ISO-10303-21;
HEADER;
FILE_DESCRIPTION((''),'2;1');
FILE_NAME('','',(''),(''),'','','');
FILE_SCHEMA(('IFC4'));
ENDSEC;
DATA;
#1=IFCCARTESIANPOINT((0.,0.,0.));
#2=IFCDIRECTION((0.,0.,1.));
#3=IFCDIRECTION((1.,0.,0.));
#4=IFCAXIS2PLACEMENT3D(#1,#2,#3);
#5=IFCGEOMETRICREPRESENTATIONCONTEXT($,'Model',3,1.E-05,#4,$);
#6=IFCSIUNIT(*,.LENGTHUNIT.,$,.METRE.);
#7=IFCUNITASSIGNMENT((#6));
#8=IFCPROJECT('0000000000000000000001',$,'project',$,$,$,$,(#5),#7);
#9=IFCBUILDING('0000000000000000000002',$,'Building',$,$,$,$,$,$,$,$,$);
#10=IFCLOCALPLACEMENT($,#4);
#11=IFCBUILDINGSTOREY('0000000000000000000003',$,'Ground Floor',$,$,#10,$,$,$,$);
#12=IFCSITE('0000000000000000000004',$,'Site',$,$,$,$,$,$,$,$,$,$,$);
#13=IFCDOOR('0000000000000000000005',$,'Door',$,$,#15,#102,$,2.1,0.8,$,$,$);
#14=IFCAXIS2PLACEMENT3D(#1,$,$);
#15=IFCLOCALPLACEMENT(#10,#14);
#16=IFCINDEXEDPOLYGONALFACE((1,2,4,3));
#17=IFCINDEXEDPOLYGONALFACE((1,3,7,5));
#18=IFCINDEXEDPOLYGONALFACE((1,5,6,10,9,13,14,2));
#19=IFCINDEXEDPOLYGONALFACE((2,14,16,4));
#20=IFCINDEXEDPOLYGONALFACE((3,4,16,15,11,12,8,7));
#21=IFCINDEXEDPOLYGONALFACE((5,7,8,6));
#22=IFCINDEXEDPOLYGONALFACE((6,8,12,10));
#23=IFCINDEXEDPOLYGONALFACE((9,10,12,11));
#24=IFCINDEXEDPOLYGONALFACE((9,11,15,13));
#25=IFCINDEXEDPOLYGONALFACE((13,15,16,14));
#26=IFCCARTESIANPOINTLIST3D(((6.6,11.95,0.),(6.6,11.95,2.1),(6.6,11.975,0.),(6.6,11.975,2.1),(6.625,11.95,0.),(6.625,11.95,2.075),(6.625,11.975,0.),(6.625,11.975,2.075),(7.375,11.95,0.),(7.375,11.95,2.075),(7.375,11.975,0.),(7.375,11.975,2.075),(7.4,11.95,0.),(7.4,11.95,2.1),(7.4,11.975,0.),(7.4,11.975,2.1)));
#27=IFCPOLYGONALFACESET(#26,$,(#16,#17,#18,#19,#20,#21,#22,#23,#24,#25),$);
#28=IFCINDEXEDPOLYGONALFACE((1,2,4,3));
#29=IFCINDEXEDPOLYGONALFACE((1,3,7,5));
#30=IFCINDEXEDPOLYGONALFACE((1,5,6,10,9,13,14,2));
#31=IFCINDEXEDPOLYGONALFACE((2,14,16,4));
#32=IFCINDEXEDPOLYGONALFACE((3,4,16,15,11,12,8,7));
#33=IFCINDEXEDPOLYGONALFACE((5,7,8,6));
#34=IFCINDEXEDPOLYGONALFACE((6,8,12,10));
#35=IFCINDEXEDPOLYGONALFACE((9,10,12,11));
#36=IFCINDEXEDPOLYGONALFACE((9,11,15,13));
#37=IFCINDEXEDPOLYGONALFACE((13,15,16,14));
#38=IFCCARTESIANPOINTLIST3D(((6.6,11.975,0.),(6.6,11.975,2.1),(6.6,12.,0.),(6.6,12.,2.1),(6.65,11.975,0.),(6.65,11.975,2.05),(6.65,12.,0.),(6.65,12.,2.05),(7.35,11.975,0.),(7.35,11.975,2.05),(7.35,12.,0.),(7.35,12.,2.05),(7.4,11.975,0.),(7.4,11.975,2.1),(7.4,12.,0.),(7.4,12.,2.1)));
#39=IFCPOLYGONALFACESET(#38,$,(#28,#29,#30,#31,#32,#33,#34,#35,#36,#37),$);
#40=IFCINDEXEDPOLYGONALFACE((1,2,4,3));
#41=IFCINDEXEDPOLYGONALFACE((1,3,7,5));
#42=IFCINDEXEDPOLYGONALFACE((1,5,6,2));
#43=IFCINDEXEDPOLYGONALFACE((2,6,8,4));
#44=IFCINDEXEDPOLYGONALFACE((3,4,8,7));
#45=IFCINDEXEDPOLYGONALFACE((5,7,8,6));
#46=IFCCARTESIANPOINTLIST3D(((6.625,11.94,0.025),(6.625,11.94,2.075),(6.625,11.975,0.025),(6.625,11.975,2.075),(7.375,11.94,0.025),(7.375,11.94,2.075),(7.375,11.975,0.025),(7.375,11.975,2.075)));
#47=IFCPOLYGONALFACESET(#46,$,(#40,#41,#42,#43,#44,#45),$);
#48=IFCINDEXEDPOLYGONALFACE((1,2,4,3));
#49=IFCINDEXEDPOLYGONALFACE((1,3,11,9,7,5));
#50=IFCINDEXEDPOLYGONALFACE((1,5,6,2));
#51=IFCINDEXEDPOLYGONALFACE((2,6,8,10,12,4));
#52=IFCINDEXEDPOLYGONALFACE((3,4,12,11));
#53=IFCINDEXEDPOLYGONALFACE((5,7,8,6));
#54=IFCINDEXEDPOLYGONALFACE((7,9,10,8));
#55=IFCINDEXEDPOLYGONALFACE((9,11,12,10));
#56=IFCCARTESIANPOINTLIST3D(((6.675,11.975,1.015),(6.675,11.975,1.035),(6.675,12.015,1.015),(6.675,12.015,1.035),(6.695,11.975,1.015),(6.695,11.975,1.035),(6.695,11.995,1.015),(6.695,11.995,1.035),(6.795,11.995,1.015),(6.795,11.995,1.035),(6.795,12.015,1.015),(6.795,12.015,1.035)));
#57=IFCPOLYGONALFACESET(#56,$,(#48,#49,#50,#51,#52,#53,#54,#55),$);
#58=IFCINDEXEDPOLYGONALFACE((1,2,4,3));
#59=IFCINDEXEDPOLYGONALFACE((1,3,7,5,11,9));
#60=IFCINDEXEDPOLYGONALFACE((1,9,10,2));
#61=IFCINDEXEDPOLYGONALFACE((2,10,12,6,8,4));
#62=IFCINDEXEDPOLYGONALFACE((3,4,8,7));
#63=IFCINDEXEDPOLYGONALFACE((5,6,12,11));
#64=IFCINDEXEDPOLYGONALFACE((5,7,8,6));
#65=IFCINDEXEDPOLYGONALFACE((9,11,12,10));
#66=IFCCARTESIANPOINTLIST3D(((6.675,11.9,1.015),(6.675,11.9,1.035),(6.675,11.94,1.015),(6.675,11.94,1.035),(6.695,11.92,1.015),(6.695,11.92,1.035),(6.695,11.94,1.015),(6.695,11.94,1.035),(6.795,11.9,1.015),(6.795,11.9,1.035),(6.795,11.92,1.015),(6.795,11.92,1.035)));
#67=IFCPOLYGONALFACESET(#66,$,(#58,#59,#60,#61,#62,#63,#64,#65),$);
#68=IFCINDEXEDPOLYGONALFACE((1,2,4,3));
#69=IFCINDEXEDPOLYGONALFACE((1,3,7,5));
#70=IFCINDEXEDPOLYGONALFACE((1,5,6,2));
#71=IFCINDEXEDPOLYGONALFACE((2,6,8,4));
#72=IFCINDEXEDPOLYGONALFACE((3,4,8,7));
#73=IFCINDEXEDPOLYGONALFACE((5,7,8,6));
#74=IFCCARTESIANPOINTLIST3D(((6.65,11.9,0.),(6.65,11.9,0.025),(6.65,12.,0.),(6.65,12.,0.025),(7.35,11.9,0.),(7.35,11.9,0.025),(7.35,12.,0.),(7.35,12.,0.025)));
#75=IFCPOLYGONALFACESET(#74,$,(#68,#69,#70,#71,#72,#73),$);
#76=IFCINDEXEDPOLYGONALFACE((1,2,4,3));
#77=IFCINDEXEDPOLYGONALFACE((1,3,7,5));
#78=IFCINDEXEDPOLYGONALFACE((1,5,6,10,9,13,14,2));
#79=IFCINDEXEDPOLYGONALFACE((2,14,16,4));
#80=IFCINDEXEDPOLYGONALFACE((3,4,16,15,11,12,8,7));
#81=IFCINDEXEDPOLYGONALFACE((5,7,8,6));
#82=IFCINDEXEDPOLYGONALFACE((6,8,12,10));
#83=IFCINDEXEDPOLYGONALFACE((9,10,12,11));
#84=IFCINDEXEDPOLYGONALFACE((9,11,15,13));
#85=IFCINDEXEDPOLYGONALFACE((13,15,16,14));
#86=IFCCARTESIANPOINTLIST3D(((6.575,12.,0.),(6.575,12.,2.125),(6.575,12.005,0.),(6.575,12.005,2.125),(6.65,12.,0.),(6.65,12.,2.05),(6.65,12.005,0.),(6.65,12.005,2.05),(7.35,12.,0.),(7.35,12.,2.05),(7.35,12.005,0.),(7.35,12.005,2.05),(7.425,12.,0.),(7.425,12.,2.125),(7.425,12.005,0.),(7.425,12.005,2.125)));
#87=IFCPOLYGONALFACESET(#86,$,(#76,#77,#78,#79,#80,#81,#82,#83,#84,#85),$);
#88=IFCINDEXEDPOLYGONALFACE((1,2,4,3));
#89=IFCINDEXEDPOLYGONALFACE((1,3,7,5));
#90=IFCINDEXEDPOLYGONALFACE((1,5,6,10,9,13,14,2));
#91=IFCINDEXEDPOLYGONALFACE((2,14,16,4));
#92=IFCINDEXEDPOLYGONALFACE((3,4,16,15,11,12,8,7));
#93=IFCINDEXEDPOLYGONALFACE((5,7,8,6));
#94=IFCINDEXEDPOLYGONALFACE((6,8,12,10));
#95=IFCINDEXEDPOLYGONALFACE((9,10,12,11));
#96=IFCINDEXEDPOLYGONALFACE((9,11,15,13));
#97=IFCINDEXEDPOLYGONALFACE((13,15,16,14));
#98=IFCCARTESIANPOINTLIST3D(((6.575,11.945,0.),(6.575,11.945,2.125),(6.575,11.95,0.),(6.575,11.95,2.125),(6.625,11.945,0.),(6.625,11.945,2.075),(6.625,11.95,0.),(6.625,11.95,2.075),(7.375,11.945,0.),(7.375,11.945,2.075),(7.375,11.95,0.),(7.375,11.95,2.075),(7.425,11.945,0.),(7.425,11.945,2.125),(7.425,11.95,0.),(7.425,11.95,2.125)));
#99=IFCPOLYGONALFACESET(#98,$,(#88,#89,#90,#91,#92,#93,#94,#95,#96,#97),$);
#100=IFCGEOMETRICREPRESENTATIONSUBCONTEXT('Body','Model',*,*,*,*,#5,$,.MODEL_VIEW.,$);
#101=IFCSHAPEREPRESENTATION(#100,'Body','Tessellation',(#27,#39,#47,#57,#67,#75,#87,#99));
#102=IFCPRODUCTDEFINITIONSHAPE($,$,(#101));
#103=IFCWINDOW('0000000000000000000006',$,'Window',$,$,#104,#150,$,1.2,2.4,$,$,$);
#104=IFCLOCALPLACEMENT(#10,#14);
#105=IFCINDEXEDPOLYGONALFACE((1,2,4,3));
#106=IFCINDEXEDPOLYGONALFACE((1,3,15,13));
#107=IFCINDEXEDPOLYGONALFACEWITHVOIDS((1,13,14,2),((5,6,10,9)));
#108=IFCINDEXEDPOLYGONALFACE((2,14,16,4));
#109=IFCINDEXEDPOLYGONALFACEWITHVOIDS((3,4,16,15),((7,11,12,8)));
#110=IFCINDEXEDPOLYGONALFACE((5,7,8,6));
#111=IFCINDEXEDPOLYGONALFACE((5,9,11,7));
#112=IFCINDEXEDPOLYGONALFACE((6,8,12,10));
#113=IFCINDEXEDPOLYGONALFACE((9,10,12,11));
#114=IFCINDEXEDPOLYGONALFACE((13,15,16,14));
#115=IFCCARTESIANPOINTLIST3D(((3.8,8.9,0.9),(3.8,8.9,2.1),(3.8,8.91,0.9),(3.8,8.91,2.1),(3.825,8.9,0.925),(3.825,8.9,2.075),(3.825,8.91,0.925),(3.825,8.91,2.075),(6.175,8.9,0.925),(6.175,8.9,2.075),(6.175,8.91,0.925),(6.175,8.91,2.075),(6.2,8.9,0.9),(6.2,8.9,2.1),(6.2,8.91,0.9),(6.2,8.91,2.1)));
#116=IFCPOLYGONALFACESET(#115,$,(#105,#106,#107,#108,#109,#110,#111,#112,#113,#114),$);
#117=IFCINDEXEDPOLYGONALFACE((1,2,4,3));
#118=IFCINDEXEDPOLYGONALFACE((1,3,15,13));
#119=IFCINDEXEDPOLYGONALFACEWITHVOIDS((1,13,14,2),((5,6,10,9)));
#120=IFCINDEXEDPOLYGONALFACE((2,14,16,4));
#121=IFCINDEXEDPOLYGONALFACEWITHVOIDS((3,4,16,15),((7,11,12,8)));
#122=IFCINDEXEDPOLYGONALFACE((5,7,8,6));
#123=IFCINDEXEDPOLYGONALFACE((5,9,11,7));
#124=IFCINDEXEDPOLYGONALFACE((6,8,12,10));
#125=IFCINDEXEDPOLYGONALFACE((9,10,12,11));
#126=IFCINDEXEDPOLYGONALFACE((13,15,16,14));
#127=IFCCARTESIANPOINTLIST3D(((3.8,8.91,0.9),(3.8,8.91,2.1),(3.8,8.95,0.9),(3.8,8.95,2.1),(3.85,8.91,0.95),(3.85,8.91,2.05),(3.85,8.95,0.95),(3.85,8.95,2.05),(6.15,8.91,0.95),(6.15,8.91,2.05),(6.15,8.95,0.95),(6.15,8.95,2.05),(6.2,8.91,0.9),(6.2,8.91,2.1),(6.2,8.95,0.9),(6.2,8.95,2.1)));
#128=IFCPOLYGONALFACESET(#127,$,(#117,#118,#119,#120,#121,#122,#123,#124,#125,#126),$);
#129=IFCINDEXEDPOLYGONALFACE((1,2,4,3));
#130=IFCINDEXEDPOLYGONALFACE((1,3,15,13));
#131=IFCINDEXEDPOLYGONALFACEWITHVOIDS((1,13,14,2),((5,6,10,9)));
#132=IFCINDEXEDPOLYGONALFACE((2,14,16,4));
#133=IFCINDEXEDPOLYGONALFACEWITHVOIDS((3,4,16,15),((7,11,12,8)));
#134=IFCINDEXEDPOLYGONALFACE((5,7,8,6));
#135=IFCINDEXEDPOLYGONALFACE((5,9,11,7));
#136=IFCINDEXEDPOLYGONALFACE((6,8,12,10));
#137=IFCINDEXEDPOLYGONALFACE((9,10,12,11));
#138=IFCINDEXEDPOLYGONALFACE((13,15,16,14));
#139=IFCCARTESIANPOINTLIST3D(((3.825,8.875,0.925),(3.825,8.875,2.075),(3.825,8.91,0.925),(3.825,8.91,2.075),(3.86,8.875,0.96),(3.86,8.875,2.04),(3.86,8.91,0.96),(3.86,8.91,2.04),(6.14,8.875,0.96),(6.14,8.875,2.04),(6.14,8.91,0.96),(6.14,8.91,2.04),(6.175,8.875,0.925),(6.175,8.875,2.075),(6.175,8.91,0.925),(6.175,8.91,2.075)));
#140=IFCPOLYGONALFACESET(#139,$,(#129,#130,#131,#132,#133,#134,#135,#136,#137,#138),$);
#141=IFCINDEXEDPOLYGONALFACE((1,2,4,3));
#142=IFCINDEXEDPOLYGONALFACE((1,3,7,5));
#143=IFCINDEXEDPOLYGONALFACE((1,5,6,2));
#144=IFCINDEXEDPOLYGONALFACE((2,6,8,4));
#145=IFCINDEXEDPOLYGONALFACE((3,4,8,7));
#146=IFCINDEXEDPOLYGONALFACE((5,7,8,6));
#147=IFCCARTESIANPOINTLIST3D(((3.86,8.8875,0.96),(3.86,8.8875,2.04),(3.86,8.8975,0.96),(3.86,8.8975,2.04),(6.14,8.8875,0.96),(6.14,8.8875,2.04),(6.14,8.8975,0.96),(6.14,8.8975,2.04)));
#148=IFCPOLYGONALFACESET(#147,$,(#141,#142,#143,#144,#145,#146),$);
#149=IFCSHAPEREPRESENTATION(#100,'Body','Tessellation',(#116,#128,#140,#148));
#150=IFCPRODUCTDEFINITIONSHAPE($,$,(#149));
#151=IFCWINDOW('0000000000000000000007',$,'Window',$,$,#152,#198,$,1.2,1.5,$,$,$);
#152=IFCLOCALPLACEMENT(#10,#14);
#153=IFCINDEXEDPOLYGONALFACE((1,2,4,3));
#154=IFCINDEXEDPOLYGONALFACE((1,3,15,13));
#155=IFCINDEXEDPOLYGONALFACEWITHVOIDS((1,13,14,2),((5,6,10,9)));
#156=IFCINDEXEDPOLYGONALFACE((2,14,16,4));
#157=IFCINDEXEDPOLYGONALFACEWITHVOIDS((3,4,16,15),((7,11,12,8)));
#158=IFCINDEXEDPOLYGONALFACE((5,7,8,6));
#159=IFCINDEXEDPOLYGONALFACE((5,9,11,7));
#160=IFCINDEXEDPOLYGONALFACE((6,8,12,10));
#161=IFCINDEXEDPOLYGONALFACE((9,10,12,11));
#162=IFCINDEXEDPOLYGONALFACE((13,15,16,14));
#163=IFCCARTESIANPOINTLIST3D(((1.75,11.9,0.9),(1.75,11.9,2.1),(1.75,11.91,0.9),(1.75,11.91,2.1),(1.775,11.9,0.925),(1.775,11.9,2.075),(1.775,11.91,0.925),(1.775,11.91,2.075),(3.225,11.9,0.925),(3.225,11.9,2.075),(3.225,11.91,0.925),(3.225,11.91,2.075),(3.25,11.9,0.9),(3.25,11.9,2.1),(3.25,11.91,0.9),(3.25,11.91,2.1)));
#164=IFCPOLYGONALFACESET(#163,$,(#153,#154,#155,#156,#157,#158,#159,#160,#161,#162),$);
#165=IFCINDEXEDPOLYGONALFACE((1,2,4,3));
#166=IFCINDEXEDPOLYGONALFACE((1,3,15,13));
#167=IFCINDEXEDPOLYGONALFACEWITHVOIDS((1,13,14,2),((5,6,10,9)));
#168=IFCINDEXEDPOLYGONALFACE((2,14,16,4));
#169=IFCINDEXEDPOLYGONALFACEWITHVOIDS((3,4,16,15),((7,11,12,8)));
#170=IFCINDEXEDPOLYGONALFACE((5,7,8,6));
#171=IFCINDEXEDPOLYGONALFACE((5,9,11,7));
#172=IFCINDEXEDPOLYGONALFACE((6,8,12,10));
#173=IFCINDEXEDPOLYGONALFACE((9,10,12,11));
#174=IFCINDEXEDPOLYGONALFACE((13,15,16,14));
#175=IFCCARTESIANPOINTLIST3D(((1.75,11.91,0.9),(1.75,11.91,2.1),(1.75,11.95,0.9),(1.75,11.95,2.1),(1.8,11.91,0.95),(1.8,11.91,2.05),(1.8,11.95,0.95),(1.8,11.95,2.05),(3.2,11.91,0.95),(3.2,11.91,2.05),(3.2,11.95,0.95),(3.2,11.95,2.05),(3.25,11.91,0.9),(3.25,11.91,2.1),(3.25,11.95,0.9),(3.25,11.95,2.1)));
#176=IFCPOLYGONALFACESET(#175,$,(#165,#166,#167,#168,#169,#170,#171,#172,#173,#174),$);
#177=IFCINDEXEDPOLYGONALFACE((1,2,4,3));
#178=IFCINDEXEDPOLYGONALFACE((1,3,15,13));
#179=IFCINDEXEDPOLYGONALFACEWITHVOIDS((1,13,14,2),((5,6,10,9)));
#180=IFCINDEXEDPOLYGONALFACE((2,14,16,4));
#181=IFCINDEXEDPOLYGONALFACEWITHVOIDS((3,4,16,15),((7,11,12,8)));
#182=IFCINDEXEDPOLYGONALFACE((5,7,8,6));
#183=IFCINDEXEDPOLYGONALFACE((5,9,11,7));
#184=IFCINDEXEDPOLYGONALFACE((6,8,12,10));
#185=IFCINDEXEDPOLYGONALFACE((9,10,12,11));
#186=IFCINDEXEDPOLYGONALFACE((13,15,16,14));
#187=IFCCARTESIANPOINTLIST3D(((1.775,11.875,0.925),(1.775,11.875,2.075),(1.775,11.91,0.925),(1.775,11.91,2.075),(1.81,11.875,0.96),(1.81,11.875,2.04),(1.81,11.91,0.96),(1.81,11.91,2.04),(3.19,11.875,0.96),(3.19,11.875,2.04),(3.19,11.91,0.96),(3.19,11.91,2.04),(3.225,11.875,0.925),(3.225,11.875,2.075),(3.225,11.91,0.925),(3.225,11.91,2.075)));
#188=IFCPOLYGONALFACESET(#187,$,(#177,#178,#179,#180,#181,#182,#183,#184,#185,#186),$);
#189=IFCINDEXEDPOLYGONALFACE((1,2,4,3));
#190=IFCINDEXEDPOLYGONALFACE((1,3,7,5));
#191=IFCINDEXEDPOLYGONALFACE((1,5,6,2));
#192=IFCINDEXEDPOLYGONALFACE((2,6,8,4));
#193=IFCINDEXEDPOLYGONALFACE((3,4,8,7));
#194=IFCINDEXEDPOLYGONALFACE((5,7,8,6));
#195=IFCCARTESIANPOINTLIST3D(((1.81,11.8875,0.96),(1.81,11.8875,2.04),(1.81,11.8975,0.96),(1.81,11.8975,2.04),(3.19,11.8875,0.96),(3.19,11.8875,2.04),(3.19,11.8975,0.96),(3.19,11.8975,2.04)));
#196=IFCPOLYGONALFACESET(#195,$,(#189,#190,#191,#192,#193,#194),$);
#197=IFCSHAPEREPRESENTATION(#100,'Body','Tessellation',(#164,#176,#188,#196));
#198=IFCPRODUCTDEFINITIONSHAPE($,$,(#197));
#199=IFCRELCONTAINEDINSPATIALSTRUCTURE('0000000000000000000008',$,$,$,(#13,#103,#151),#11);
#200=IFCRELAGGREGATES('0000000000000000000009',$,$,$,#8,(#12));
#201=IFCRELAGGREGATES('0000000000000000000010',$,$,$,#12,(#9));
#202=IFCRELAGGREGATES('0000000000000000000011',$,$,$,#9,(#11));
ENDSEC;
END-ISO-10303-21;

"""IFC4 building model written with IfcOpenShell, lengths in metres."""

from ifc_helpers import new_model, si_unit, frame, origin_with_axes, place, context, subcontext, project, spatial, line, indexed_curve, outline, extrude, element, save


model = new_model("IFC4")

# Units and contexts
model_context = context("Model", 3, precision=1e-05, world=origin_with_axes())
body_context = subcontext(model_context, "Body", "Model", "MODEL_VIEW")
ifc_project = project(units=[si_unit("LENGTHUNIT", "METRE")], contexts=[model_context])

# Site, building, storey
site = spatial("IfcSite", under=ifc_project, Name="Site")
building = spatial("IfcBuilding", under=site, Name="Building")
storey_placement = place(None, origin_with_axes())
storey = spatial("IfcBuildingStorey", under=building, at=storey_placement, Name="Ground Floor")

# Door
door_1_placement = place(storey_placement, frame((7.4, 12.0, 0.0), z_axis=(0.0, 0.0, 1.0), x_axis=(-1.0, 0.0, 0.0)))
element("IfcDoor", 1, at=door_1_placement, inside=storey, Name="Door", OverallHeight=2.1, OverallWidth=0.8, context=body_context, shape_type="SweptSolid", body=[
    extrude(outline(indexed_curve([(0.0, 0.0), (0.0, 2.1), (0.8, 2.1), (0.8, 0.0), (0.775, 0.0), (0.775, 2.075), (0.025, 2.075), (0.025, 0.0)], segments=[line(1, 2, 3, 4, 5, 6, 7, 8, 1)])), frame((0.0, 0.025, 0.0), z_axis=(0.0, -1.0, 0.0), x_axis=(1.0, 0.0, 0.0)), (0.0, 0.0, -1.0), 0.025),
    extrude(outline(indexed_curve([(0.0, 0.0), (0.0, 2.1), (0.8, 2.1), (0.8, 0.0), (0.75, 0.0), (0.75, 2.05), (0.05, 2.05), (0.05, 0.0)], segments=[line(1, 2, 3, 4, 5, 6, 7, 8, 1)])), frame((0.0, 0.0, 0.0), z_axis=(0.0, -1.0, 0.0), x_axis=(1.0, 0.0, 0.0)), (0.0, 0.0, -1.0), 0.025),
    extrude(outline(indexed_curve([(0.0, 0.0), (0.75, 0.0), (0.75, 0.035), (0.0, 0.035)], segments=[line(1, 2, 3, 4, 1)])), frame((0.025, 0.025, 0.025), z_axis=(0.0, 0.0, 1.0), x_axis=(1.0, 0.0, 0.0)), (0.0, 0.0, 1.0), 2.05),
    extrude(outline(indexed_curve([(0.0, 0.0), (0.0, -0.04), (-0.12, -0.04), (-0.12, -0.02), (-0.02, -0.02), (-0.02, 0.0)], segments=[line(1, 2, 3, 4, 5, 6, 1)])), frame((0.725, 0.025, 1.015), z_axis=(0.0, 0.0, 1.0), x_axis=(1.0, 0.0, 0.0)), (0.0, 0.0, 1.0), 0.02),
    extrude(outline(indexed_curve([(0.0, 0.0), (0.0, 0.04), (-0.12, 0.04), (-0.12, 0.02), (-0.02, 0.02), (-0.02, 0.0)], segments=[line(1, 2, 3, 4, 5, 6, 1)])), frame((0.725, 0.06, 1.015), z_axis=(0.0, 0.0, 1.0), x_axis=(1.0, 0.0, 0.0)), (0.0, 0.0, 1.0), 0.02),
    extrude(outline(indexed_curve([(0.0, 0.0), (0.7, 0.0), (0.7, 0.1), (0.0, 0.1)], segments=[line(1, 2, 3, 4, 1)])), frame((0.05, 0.0, 0.0), z_axis=(0.0, 0.0, 1.0), x_axis=(1.0, 0.0, 0.0)), (0.0, 0.0, 1.0), 0.025),
    extrude(outline(indexed_curve([(0.0, 0.0), (0.0, 2.125), (0.85, 2.125), (0.85, 0.0), (0.775, 0.0), (0.775, 2.05), (0.075, 2.05), (0.075, 0.0)], segments=[line(1, 2, 3, 4, 5, 6, 7, 8, 1)])), frame((-0.025, -0.005, 0.0), z_axis=(0.0, -1.0, 0.0), x_axis=(1.0, 0.0, 0.0)), (0.0, 0.0, -1.0), 0.005),
    extrude(outline(indexed_curve([(0.0, 0.0), (0.0, 2.125), (0.85, 2.125), (0.85, 0.0), (0.8, 0.0), (0.8, 2.075), (0.05, 2.075), (0.05, 0.0)], segments=[line(1, 2, 3, 4, 5, 6, 7, 8, 1)])), frame((-0.025, 0.05, 0.0), z_axis=(0.0, -1.0, 0.0), x_axis=(1.0, 0.0, 0.0)), (0.0, 0.0, -1.0), 0.005),
])

# Windows
window_placement = place(storey_placement, frame((6.2, 9.0, 0.9), z_axis=(0.0, 0.0, 1.0), x_axis=(-1.0, 0.0, 0.0)))
element("IfcWindow", 2, at=window_placement, inside=storey, Name="Window", OverallHeight=1.2, OverallWidth=2.4, context=body_context, shape_type="SweptSolid", body=[
    extrude(outline(indexed_curve([(0.0, 0.0), (2.4, 0.0), (2.4, 1.2), (0.0, 1.2)], segments=[line(1, 2, 3, 4, 1)]), holes=[indexed_curve([(0.025, 0.025), (2.375, 0.025), (2.375, 1.175), (0.025, 1.175)], segments=[line(1, 2, 3, 4, 1)])]), frame((0.0, 0.09, 0.0), z_axis=(0.0, -1.0, 0.0), x_axis=(1.0, 0.0, 0.0)), (0.0, 0.0, -1.0), 0.01),
    extrude(outline(indexed_curve([(0.0, 0.0), (2.4, 0.0), (2.4, 1.2), (0.0, 1.2)], segments=[line(1, 2, 3, 4, 1)]), holes=[indexed_curve([(0.05, 0.05), (2.35, 0.05), (2.35, 1.15), (0.05, 1.15)], segments=[line(1, 2, 3, 4, 1)])]), frame((0.0, 0.05, 0.0), z_axis=(0.0, -1.0, 0.0), x_axis=(1.0, 0.0, 0.0)), (0.0, 0.0, -1.0), 0.04),
    extrude(outline(indexed_curve([(0.0, 0.0), (2.35, 0.0), (2.35, 1.15), (0.0, 1.15)], segments=[line(1, 2, 3, 4, 1)]), holes=[indexed_curve([(0.035, 0.035), (2.315, 0.035), (2.315, 1.115), (0.035, 1.115)], segments=[line(1, 2, 3, 4, 1)])]), frame((0.025, 0.09, 0.025), z_axis=(0.0, -1.0, 0.0), x_axis=(1.0, 0.0, 0.0)), (0.0, 0.0, -1.0), 0.035),
    extrude(outline(indexed_curve([(0.035, 0.035), (2.315, 0.035), (2.315, 1.115), (0.035, 1.115)], segments=[line(1, 2, 3, 4, 1)])), frame((0.025, 0.1025, 0.025), z_axis=(0.0, -1.0, 0.0), x_axis=(1.0, 0.0, 0.0)), (0.0, 0.0, -1.0), 0.01),
])
for number, where, z_axis, x_axis, name in (
    (3, (3.25, 12.0, 0.9), (0.0, 0.0, 1.0), (-1.0, 0.0, 0.0), "Window"),
):
    element("IfcWindow", number, at=place(storey_placement, frame(where, z_axis=z_axis, x_axis=x_axis)), inside=storey, Name=name, OverallHeight=1.2, OverallWidth=1.5, context=body_context, shape_type="SweptSolid", body=[
        extrude(outline(indexed_curve([(0.0, 0.0), (1.5, 0.0), (1.5, 1.2), (0.0, 1.2)], segments=[line(1, 2, 3, 4, 1)]), holes=[indexed_curve([(0.025, 0.025), (1.475, 0.025), (1.475, 1.175), (0.025, 1.175)], segments=[line(1, 2, 3, 4, 1)])]), frame((0.0, 0.09, 0.0), z_axis=(0.0, -1.0, 0.0), x_axis=(1.0, 0.0, 0.0)), (0.0, 0.0, -1.0), 0.01),
        extrude(outline(indexed_curve([(0.0, 0.0), (1.5, 0.0), (1.5, 1.2), (0.0, 1.2)], segments=[line(1, 2, 3, 4, 1)]), holes=[indexed_curve([(0.05, 0.05), (1.45, 0.05), (1.45, 1.15), (0.05, 1.15)], segments=[line(1, 2, 3, 4, 1)])]), frame((0.0, 0.05, 0.0), z_axis=(0.0, -1.0, 0.0), x_axis=(1.0, 0.0, 0.0)), (0.0, 0.0, -1.0), 0.04),
        extrude(outline(indexed_curve([(0.0, 0.0), (1.45, 0.0), (1.45, 1.15), (0.0, 1.15)], segments=[line(1, 2, 3, 4, 1)]), holes=[indexed_curve([(0.035, 0.035), (1.415, 0.035), (1.415, 1.115), (0.035, 1.115)], segments=[line(1, 2, 3, 4, 1)])]), frame((0.025, 0.09, 0.025), z_axis=(0.0, -1.0, 0.0), x_axis=(1.0, 0.0, 0.0)), (0.0, 0.0, -1.0), 0.035),
        extrude(outline(indexed_curve([(0.035, 0.035), (1.415, 0.035), (1.415, 1.115), (0.035, 1.115)], segments=[line(1, 2, 3, 4, 1)])), frame((0.025, 0.1025, 0.025), z_axis=(0.0, -1.0, 0.0), x_axis=(1.0, 0.0, 0.0)), (0.0, 0.0, -1.0), 0.01),
    ])

save(model, "model.ifc")
